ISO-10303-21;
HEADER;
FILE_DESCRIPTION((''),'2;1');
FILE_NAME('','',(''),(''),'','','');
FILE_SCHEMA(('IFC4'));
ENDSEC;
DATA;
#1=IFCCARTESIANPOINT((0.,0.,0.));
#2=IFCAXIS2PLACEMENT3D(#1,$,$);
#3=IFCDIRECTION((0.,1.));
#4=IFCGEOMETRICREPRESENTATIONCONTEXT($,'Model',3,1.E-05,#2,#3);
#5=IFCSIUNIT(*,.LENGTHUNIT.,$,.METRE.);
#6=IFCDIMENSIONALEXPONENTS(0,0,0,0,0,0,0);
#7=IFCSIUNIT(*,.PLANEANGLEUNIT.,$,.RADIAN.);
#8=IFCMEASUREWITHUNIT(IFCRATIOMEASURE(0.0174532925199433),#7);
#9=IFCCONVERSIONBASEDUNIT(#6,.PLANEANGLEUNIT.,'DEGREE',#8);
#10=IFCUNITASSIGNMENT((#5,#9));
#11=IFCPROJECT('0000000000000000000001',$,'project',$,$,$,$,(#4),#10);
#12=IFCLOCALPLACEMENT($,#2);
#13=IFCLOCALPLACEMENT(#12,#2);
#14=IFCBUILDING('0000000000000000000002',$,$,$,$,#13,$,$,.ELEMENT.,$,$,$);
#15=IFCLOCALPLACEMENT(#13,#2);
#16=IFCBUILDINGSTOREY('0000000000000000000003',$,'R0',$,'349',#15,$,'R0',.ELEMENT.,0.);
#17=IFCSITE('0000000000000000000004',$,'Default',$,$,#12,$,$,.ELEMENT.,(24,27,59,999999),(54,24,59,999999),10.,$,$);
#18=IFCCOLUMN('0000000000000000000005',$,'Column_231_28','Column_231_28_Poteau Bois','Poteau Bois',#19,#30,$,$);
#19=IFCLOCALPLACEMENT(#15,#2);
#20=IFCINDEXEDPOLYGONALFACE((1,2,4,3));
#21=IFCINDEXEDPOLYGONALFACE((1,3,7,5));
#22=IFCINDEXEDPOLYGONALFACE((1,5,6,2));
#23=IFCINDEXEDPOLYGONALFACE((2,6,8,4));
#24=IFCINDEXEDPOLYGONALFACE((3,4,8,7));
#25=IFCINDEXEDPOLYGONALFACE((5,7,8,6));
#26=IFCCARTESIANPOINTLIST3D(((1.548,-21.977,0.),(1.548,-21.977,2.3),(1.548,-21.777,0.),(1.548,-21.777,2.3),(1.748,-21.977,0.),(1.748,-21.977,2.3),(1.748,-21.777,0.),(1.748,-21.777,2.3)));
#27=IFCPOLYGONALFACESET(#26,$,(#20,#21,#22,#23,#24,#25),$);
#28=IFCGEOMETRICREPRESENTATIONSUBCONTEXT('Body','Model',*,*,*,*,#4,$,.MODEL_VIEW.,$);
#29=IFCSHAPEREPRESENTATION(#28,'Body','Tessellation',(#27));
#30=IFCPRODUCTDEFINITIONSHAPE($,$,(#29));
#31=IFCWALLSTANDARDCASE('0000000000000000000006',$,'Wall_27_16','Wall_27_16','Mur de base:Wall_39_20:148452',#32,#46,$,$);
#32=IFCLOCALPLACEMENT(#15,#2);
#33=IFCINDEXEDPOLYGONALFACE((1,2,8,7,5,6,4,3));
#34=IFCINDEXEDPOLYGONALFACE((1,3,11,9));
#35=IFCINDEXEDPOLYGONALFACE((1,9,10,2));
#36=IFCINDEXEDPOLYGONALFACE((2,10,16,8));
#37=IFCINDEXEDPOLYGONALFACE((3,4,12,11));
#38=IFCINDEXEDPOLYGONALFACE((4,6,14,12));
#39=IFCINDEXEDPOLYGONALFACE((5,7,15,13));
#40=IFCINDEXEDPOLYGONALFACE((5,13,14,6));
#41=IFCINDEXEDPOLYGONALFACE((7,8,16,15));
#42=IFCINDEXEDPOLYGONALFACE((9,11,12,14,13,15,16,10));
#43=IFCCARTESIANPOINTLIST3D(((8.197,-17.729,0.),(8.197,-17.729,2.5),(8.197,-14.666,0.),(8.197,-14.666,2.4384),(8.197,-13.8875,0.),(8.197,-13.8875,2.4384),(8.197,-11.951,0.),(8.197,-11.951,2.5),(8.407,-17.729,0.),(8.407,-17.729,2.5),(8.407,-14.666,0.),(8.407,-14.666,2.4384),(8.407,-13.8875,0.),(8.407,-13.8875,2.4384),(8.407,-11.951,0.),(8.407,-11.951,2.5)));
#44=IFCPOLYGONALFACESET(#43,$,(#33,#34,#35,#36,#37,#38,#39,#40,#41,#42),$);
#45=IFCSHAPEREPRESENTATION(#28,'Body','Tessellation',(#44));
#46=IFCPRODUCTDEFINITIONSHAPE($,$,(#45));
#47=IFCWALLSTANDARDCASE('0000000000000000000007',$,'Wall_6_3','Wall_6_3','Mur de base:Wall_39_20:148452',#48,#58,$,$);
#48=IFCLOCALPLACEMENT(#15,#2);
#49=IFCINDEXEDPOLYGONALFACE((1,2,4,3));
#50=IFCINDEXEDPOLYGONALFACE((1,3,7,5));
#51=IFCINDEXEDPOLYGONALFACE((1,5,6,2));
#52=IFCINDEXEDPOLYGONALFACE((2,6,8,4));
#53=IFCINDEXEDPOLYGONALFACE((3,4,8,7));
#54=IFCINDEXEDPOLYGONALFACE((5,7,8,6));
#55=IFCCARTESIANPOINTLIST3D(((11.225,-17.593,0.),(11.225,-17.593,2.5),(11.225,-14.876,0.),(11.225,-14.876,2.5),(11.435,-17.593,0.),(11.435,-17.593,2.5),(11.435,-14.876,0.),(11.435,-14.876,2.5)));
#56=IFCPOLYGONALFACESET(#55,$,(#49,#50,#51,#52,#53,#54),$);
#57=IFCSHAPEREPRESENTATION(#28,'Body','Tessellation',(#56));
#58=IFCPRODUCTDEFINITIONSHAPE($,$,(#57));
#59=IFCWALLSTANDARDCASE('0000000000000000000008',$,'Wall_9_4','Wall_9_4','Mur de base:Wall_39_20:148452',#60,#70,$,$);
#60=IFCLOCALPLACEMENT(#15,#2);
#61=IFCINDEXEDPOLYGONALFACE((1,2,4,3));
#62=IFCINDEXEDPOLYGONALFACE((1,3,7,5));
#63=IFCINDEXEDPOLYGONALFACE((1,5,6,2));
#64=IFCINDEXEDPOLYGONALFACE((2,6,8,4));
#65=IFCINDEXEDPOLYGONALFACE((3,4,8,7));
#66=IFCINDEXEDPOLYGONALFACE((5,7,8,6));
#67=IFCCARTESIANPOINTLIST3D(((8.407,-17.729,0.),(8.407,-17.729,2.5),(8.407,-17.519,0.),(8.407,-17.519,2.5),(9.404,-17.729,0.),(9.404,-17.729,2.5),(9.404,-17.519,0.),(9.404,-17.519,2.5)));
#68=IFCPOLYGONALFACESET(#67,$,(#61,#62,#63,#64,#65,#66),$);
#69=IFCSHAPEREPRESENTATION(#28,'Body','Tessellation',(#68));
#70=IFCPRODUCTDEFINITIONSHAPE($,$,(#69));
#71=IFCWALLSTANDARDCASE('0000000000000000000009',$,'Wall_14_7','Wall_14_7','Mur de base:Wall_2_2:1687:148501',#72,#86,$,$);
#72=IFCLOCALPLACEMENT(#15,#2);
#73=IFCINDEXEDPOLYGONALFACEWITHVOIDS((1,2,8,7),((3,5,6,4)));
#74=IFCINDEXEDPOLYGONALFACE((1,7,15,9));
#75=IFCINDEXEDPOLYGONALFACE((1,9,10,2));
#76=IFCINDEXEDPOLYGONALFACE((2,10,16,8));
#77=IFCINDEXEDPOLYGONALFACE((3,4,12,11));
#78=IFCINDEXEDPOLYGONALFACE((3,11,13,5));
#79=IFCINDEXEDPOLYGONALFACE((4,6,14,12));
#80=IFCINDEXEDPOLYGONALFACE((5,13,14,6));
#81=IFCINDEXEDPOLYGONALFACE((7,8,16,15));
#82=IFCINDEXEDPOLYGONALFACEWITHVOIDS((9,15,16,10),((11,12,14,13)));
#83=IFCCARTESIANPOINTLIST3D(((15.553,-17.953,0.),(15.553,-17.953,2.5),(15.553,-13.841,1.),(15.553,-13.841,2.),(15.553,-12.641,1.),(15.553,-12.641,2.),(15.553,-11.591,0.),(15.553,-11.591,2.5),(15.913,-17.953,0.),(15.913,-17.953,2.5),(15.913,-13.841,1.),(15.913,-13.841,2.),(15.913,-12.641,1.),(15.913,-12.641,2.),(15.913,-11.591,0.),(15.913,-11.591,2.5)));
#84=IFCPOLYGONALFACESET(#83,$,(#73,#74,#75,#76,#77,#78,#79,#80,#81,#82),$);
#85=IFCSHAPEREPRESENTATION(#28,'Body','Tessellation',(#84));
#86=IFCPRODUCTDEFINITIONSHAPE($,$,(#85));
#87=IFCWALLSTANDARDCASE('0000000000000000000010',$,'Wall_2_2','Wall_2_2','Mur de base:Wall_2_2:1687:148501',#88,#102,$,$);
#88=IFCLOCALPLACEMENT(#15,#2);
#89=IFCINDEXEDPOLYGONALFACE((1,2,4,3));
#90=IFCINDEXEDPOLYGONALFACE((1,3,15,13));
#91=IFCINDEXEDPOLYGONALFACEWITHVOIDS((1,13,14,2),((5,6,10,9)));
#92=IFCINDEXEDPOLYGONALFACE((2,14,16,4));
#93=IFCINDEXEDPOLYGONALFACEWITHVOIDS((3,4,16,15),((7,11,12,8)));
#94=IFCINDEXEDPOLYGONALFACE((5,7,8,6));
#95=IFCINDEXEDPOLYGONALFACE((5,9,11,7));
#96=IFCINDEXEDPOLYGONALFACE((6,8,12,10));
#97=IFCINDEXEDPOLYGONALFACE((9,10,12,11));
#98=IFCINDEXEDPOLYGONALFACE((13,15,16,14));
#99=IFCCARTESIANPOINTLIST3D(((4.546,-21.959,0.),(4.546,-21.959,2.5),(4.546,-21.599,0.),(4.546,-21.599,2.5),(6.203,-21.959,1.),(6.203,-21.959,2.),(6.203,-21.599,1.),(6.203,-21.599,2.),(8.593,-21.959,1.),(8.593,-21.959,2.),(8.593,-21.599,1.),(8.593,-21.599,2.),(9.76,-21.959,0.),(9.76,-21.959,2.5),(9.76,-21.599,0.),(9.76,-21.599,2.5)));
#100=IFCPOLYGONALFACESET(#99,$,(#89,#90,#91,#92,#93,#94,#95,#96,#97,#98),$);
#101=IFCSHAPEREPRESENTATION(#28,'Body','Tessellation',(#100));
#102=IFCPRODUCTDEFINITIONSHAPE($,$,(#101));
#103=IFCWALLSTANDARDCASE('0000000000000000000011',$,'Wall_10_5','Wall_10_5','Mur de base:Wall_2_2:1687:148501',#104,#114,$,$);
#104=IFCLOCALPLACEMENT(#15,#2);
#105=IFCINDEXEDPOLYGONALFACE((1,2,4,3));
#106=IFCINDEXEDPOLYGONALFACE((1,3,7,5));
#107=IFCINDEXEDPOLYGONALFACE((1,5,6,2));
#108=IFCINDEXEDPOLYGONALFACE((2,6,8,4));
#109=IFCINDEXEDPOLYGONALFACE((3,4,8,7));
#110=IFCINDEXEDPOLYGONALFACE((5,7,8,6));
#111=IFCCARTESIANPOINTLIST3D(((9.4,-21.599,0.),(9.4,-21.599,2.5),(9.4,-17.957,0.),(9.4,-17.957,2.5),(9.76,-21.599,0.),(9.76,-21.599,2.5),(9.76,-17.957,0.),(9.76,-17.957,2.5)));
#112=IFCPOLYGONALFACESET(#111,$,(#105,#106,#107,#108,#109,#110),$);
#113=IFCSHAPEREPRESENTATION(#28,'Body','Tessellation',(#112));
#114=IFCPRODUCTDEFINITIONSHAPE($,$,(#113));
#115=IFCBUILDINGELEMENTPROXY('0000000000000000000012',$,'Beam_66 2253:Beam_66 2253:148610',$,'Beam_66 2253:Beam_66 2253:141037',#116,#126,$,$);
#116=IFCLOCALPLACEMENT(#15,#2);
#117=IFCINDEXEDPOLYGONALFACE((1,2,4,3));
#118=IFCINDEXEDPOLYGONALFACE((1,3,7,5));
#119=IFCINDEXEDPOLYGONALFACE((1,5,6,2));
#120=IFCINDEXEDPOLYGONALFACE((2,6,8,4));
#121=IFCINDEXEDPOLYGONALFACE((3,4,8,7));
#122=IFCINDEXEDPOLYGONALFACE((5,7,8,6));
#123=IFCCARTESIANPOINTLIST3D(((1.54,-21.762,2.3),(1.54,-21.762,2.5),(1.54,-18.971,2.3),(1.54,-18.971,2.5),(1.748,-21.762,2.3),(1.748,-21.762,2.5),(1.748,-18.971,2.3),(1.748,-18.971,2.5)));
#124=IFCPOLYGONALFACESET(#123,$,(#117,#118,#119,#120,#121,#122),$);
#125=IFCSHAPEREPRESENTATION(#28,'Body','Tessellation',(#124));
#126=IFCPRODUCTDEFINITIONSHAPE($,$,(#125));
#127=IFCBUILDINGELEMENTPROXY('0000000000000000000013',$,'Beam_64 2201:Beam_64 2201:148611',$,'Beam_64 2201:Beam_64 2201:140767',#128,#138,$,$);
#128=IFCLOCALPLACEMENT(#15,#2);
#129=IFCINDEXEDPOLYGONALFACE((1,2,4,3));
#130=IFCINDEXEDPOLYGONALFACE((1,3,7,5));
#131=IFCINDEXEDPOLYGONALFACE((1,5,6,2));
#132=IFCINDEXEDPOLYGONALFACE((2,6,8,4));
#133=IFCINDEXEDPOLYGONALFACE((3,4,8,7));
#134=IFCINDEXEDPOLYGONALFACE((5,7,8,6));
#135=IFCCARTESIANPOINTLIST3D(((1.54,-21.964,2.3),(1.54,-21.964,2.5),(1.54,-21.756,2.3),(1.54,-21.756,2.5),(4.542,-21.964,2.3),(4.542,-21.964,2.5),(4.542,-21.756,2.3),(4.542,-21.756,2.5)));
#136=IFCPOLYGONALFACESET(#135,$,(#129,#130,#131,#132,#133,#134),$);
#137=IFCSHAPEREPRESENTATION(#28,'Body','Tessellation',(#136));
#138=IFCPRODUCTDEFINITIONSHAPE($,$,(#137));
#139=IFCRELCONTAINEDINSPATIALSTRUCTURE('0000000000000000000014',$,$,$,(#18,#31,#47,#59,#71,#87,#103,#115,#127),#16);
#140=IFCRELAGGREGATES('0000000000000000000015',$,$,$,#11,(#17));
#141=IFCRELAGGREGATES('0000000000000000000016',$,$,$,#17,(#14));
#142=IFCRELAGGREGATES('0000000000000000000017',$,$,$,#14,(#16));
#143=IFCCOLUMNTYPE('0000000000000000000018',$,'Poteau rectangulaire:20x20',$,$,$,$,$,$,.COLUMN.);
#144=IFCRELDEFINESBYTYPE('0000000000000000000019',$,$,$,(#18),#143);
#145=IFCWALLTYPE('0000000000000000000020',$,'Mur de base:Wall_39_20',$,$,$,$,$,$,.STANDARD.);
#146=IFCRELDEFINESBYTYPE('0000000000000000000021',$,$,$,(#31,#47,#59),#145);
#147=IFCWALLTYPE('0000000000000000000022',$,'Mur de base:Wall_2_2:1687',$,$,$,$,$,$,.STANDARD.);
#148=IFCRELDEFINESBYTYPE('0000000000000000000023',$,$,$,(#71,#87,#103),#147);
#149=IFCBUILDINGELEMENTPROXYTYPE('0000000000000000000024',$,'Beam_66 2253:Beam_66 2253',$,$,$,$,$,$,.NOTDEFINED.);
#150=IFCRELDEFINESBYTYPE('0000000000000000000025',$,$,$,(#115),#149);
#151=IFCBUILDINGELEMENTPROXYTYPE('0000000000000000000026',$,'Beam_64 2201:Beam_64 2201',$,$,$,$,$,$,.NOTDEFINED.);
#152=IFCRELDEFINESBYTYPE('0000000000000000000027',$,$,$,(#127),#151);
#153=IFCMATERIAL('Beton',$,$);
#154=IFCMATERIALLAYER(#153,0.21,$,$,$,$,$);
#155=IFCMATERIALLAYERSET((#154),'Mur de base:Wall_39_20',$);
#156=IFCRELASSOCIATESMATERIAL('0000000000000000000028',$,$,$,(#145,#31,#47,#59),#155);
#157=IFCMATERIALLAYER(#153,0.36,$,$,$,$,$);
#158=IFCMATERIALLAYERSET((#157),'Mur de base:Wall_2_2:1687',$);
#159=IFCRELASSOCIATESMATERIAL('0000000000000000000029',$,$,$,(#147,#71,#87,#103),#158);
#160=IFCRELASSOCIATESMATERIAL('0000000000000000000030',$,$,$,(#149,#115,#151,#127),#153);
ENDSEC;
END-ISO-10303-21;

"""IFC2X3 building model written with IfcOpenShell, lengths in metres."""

from ifc_helpers import new_model, entity, si_unit, converted_unit, direction, frame, frame_2d, origin, origin_2d_with_axis, place, context, subcontext, project, spatial, rectangle, extrude, source, transform, mapped, material, layer, layer_set, layer_usage, type_object, type_shapes, element, save


model = new_model("IFC2X3")

# Units and contexts
model_context = context("Model", 3, precision=1e-05, world=origin(), true_north=direction((0.0, 1.0)))
body_context = subcontext(model_context, "Body", "Model", "MODEL_VIEW")
ifc_project = project(units=[si_unit("LENGTHUNIT", "METRE"), converted_unit("PLANEANGLEUNIT", "DEGREE", entity("IfcRatioMeasure", 0.0174532925199433), si_unit("PLANEANGLEUNIT", "RADIAN"), dimensions=[0, 0, 0, 0, 0, 0, 0])], contexts=[model_context])

# Site, building, storey
site_placement = place(None, origin())
site = spatial("IfcSite", under=ifc_project, at=site_placement, Name="Default", CompositionType="ELEMENT", RefLatitude=(24, 27, 59, 999999), RefLongitude=(54, 24, 59, 999999), RefElevation=10.0)
building_placement = place(site_placement, origin())
building = spatial("IfcBuilding", under=site, at=building_placement, CompositionType="ELEMENT")
storey_placement = place(building_placement, origin())
storey = spatial("IfcBuildingStorey", under=building, at=storey_placement, Name="R0", ObjectType="349", LongName="R0", CompositionType="ELEMENT", Elevation=0.0)

# Column
column_type = type_object("IfcColumnType", Name="Poteau rectangulaire:20x20", PredefinedType="COLUMN")
shared_shape_1 = source(origin(), body_context, "Body", "SweptSolid", [
    extrude(rectangle(XDim=0.2, YDim=0.2, at=origin_2d_with_axis()), frame((0.0, 0.0, 0.0), z_axis=(0.0, 0.0, 1.0), x_axis=(-1.0, 0.0, 0.0)), (0.0, 0.0, 1.0), 2.3),
])
type_shapes(column_type, [shared_shape_1])
column_placement = place(storey_placement, frame((1.648, -21.877, 0.0), z_axis=(0.0, 0.0, 1.0), x_axis=(0.0, 1.0, 0.0)))
element("IfcColumn", 1, at=column_placement, inside=storey, type_object=column_type, Name="Column_231_28", Description="Column_231_28_Poteau Bois", ObjectType="Poteau Bois", context=body_context, shape_type="MappedRepresentation", body=[
    mapped(shared_shape_1, transform((0.0, 0.0, 0.0), scale=1.0)),
])

# Wall, opening
ifc_material_1 = material(Name="Beton")
ifc_layer_1 = layer(ifc_material_1, 0.21)
ifc_layer_set_1 = layer_set([ifc_layer_1], Name="Mur de base:Wall_39_20")
ifc_layer_usage_1 = layer_usage(ifc_layer_set_1, "AXIS2", "NEGATIVE", 0.105)
wall_type_1 = type_object("IfcWallType", Name="Mur de base:Wall_39_20", PredefinedType="STANDARD", material=ifc_layer_set_1)
wall_1_placement = place(storey_placement, frame((8.302, -17.729, 0.0), z_axis=(0.0, 0.0, 1.0), x_axis=(0.0, 1.0, 0.0)))
wall_1 = element("IfcWallStandardCase", 2, at=wall_1_placement, inside=storey, type_object=wall_type_1, material=ifc_layer_usage_1, Name="Wall_27_16", Description="Wall_27_16", ObjectType="Mur de base:Wall_39_20:148452", context=body_context, shape_type="SweptSolid", body=[
    extrude(rectangle(XDim=5.778, YDim=0.21, at=frame_2d((2.889, 0.0), x_axis=(-1.0, 0.0))), origin(), (0.0, 0.0, 1.0), 2.5),
])
opening_1_placement = place(wall_1_placement, origin())
element("IfcOpeningElement", 3, at=opening_1_placement, cuts=wall_1, ObjectType="Opening", context=body_context, shape_type="SweptSolid", body=[
    extrude(rectangle(XDim=2.4384, YDim=0.7785, at=frame_2d((0.0, 0.0), x_axis=(1.0, 0.0))), frame((3.4522, -0.105, 1.2192), z_axis=(0.0, 1.0, 0.0), x_axis=(0.0, 0.0, -1.0)), (0.0, 0.0, 1.0), 0.21),
])

# Walls
ifc_layer_usage_2 = layer_usage(ifc_layer_set_1, "AXIS2", "NEGATIVE", 0.105)
wall_2_placement = place(storey_placement, frame((11.33, -17.593, 0.0), z_axis=(0.0, 0.0, 1.0), x_axis=(0.0, 1.0, 0.0)))
element("IfcWallStandardCase", 4, at=wall_2_placement, inside=storey, type_object=wall_type_1, material=ifc_layer_usage_2, Name="Wall_6_3", Description="Wall_6_3", ObjectType="Mur de base:Wall_39_20:148452", context=body_context, shape_type="SweptSolid", body=[
    extrude(rectangle(XDim=2.717, YDim=0.21, at=frame_2d((1.3585, 0.0), x_axis=(-1.0, 0.0))), origin(), (0.0, 0.0, 1.0), 2.5),
])
ifc_layer_usage_3 = layer_usage(ifc_layer_set_1, "AXIS2", "NEGATIVE", 0.105)
wall_3_placement = place(storey_placement, frame((8.407, -17.624, 0.0)))
element("IfcWallStandardCase", 5, at=wall_3_placement, inside=storey, type_object=wall_type_1, material=ifc_layer_usage_3, Name="Wall_9_4", Description="Wall_9_4", ObjectType="Mur de base:Wall_39_20:148452", context=body_context, shape_type="SweptSolid", body=[
    extrude(rectangle(XDim=0.997, YDim=0.21, at=frame_2d((0.4985, 0.0), x_axis=(-1.0, 0.0))), origin(), (0.0, 0.0, 1.0), 2.5),
])

# Shared definitions
ifc_layer_2 = layer(ifc_material_1, 0.36)
ifc_layer_set_2 = layer_set([ifc_layer_2], Name="Mur de base:Wall_2_2:1687")
wall_type_2 = type_object("IfcWallType", Name="Mur de base:Wall_2_2:1687", PredefinedType="STANDARD", material=ifc_layer_set_2)

# Wall, opening
ifc_layer_usage_4 = layer_usage(ifc_layer_set_2, "AXIS2", "NEGATIVE", 0.18)
wall_4_placement = place(storey_placement, frame((15.733, -17.953, 0.0), z_axis=(0.0, 0.0, 1.0), x_axis=(0.0, 1.0, 0.0)))
wall_4 = element("IfcWallStandardCase", 6, at=wall_4_placement, inside=storey, type_object=wall_type_2, material=ifc_layer_usage_4, Name="Wall_14_7", Description="Wall_14_7", ObjectType="Mur de base:Wall_2_2:1687:148501", context=body_context, shape_type="SweptSolid", body=[
    extrude(rectangle(XDim=6.362, YDim=0.36, at=frame_2d((3.181, 0.0), x_axis=(-1.0, 0.0))), origin(), (0.0, 0.0, 1.0), 2.5),
])
opening_2_placement = place(wall_4_placement, origin())
element("IfcOpeningElement", 7, at=opening_2_placement, cuts=wall_4, ObjectType="Opening", context=body_context, shape_type="SweptSolid", body=[
    extrude(rectangle(XDim=1.0, YDim=1.2, at=frame_2d((0.0, 0.0), x_axis=(1.0, 0.0))), frame((4.712, -0.19, 1.5), z_axis=(0.0, 1.0, 0.0), x_axis=(0.0, 0.0, -1.0)), (0.0, 0.0, 1.0), 0.38),
])

# Wall, opening
ifc_layer_usage_5 = layer_usage(ifc_layer_set_2, "AXIS2", "NEGATIVE", 0.18)
wall_5_placement = place(storey_placement, frame((4.546, -21.779, 0.0)))
wall_5 = element("IfcWallStandardCase", 8, at=wall_5_placement, inside=storey, type_object=wall_type_2, material=ifc_layer_usage_5, Name="Wall_2_2", Description="Wall_2_2", ObjectType="Mur de base:Wall_2_2:1687:148501", context=body_context, shape_type="SweptSolid", body=[
    extrude(rectangle(XDim=5.214, YDim=0.36, at=frame_2d((2.607, 0.0), x_axis=(-1.0, 0.0))), origin(), (0.0, 0.0, 1.0), 2.5),
])
opening_3_placement = place(wall_5_placement, origin())
element("IfcOpeningElement", 9, at=opening_3_placement, cuts=wall_5, ObjectType="Opening", context=body_context, shape_type="SweptSolid", body=[
    extrude(rectangle(XDim=1.0, YDim=2.39, at=frame_2d((0.0, 0.0), x_axis=(1.0, 0.0))), frame((2.852, -0.19, 1.5), z_axis=(0.0, 1.0, 0.0), x_axis=(0.0, 0.0, -1.0)), (0.0, 0.0, 1.0), 0.38),
])

# Wall
ifc_layer_usage_6 = layer_usage(ifc_layer_set_2, "AXIS2", "NEGATIVE", 0.18)
wall_6_placement = place(storey_placement, frame((9.58, -21.599, 0.0), z_axis=(0.0, 0.0, 1.0), x_axis=(0.0, 1.0, 0.0)))
element("IfcWallStandardCase", 10, at=wall_6_placement, inside=storey, type_object=wall_type_2, material=ifc_layer_usage_6, Name="Wall_10_5", Description="Wall_10_5", ObjectType="Mur de base:Wall_2_2:1687:148501", context=body_context, shape_type="SweptSolid", body=[
    extrude(rectangle(XDim=3.642, YDim=0.36, at=frame_2d((1.821, 0.0), x_axis=(-1.0, 0.0))), origin(), (0.0, 0.0, 1.0), 2.5),
])

# Building element proxies
building_element_proxy_type_1 = type_object("IfcBuildingElementProxyType", Name="Beam_66 2253:Beam_66 2253", PredefinedType="NOTDEFINED", material=ifc_material_1)
shared_shape_2 = source(origin(), body_context, "Body", "SweptSolid", [
    extrude(rectangle(XDim=0.208, YDim=2.791, at=origin_2d_with_axis()), frame((1.3955, 0.0, 0.0), z_axis=(0.0, 0.0, 1.0), x_axis=(0.0, 1.0, 0.0)), (0.0, 0.0, 1.0), 0.2),
])
type_shapes(building_element_proxy_type_1, [shared_shape_2])
proxy_1_placement = place(storey_placement, frame((1.644, -18.971, 2.3), z_axis=(0.0, 0.0, 1.0), x_axis=(0.0, -1.0, 0.0)))
element("IfcBuildingElementProxy", 11, at=proxy_1_placement, inside=storey, type_object=building_element_proxy_type_1, material=ifc_material_1, Name="Beam_66 2253:Beam_66 2253:148610", ObjectType="Beam_66 2253:Beam_66 2253:141037", context=body_context, shape_type="MappedRepresentation", body=[
    mapped(shared_shape_2, transform((0.0, 0.0, 0.0), scale=1.0)),
])
building_element_proxy_type_2 = type_object("IfcBuildingElementProxyType", Name="Beam_64 2201:Beam_64 2201", PredefinedType="NOTDEFINED", material=ifc_material_1)
shared_shape_3 = source(origin(), body_context, "Body", "SweptSolid", [
    extrude(rectangle(XDim=0.208, YDim=3.002, at=origin_2d_with_axis()), frame((1.501, 0.0, 0.0), z_axis=(0.0, 0.0, 1.0), x_axis=(0.0, 1.0, 0.0)), (0.0, 0.0, 1.0), 0.2),
])
type_shapes(building_element_proxy_type_2, [shared_shape_3])
proxy_2_placement = place(storey_placement, frame((1.54, -21.86, 2.3)))
element("IfcBuildingElementProxy", 12, at=proxy_2_placement, inside=storey, type_object=building_element_proxy_type_2, material=ifc_material_1, Name="Beam_64 2201:Beam_64 2201:148611", ObjectType="Beam_64 2201:Beam_64 2201:140767", context=body_context, shape_type="MappedRepresentation", body=[
    mapped(shared_shape_3, transform((0.0, 0.0, 0.0), scale=1.0)),
])

save(model, "model.ifc")
